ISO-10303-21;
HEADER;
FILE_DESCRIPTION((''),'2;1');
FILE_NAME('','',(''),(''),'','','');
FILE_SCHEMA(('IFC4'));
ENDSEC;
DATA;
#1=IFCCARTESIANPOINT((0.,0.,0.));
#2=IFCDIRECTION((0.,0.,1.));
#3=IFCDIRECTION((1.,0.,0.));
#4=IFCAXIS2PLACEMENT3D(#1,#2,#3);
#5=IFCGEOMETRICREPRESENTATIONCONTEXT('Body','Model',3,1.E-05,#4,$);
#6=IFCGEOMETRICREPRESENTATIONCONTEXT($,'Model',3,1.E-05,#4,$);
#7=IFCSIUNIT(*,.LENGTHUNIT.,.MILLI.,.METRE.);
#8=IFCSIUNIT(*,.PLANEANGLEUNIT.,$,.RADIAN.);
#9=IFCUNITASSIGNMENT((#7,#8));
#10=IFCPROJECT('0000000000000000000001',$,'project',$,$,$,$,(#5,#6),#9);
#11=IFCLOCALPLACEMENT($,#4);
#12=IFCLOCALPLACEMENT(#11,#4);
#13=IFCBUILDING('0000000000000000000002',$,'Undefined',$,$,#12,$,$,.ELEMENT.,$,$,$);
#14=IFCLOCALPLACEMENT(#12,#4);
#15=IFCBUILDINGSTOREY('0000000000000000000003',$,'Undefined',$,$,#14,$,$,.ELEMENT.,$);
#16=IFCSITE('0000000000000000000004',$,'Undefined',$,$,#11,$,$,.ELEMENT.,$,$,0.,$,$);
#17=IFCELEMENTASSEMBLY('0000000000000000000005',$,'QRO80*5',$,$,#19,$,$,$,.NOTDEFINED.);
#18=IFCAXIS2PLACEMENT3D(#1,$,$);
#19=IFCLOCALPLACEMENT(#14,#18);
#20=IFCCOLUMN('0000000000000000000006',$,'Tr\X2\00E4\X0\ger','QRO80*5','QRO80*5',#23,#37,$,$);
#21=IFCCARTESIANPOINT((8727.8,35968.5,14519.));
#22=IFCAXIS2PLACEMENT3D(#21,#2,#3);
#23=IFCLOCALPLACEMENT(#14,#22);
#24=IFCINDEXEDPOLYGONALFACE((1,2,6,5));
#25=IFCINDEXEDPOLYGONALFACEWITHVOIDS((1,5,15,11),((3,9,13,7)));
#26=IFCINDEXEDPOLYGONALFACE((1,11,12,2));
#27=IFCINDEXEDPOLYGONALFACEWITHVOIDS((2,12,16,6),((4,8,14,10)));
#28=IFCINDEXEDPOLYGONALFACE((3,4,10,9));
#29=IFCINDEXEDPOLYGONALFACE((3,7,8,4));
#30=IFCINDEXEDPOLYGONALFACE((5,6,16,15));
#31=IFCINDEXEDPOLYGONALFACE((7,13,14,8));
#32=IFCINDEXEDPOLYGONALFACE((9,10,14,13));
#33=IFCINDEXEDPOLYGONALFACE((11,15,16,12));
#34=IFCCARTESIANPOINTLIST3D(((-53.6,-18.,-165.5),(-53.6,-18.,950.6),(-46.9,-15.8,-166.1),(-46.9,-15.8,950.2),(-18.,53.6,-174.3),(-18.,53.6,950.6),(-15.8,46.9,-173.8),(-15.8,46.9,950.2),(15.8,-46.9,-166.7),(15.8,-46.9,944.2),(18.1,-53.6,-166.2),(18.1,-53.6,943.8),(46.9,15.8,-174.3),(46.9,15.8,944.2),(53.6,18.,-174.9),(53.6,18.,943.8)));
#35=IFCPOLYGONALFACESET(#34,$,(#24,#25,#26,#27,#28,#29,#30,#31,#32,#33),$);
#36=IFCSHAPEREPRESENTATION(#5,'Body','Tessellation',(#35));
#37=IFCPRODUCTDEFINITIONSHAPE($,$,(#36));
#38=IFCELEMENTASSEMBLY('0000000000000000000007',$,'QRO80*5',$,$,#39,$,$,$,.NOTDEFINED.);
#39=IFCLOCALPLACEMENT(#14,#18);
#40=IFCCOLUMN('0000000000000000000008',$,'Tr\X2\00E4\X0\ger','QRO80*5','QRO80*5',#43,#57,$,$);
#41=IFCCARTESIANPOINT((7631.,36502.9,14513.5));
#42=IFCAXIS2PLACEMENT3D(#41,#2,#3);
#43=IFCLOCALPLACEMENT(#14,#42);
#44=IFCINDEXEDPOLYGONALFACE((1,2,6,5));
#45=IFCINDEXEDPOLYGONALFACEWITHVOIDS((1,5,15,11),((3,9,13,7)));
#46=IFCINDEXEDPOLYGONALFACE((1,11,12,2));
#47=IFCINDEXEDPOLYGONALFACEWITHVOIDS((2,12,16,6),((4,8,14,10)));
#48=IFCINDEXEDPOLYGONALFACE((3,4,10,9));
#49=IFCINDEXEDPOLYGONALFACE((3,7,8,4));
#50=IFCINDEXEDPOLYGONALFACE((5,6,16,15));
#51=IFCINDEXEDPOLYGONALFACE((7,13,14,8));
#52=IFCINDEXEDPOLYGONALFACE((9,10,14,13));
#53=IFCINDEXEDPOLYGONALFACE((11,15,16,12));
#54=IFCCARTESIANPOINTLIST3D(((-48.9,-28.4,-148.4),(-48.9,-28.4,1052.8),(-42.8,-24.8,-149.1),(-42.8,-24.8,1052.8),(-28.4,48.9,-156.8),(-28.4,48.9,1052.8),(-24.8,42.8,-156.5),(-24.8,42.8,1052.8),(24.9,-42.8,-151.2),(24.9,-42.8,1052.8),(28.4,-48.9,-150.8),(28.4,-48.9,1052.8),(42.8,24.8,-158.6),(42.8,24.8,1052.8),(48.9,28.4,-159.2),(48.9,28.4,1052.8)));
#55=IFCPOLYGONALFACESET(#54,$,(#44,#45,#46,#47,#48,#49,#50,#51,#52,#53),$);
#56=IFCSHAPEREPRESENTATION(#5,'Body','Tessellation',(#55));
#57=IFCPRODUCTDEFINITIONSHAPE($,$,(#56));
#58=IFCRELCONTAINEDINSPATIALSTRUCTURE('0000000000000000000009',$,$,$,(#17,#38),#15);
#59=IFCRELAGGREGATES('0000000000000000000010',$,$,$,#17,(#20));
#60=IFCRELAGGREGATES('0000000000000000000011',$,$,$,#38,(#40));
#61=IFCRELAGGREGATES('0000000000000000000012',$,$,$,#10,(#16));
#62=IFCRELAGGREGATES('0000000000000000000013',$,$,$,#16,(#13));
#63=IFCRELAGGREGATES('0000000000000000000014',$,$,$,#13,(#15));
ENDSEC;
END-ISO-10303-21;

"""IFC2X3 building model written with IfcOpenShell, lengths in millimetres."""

from ifc_helpers import new_model, si_unit, frame, origin_with_axes, origin_2d_with_axis, place, context, project, spatial, hollow_rectangle, extrude, clip, halfspace, element, aggregate, save


model = new_model("IFC2X3")

# Units and contexts
model_context_1 = context("Model", 3, precision=1e-05, world=origin_with_axes(), identifier="Body")
model_context_2 = context("Model", 3, precision=1e-05, world=origin_with_axes())
ifc_project = project(units=[si_unit("LENGTHUNIT", "METRE", prefix="MILLI"), si_unit("PLANEANGLEUNIT", "RADIAN")], contexts=[model_context_1, model_context_2])

# Site, building, storey
site_placement = place(None, origin_with_axes())
site = spatial("IfcSite", under=ifc_project, at=site_placement, Name="Undefined", CompositionType="ELEMENT", RefElevation=0.0)
building_placement = place(site_placement, origin_with_axes())
building = spatial("IfcBuilding", under=site, at=building_placement, Name="Undefined", CompositionType="ELEMENT")
storey_placement = place(building_placement, origin_with_axes())
storey = spatial("IfcBuildingStorey", under=building, at=storey_placement, Name="Undefined", CompositionType="ELEMENT")

# Element assemblies, columns
assembly_1 = element("IfcElementAssembly", 1, inside=storey, Name="QRO80*5", PredefinedType="NOTDEFINED")
column_1_placement = place(storey_placement, frame((8727.8, 35968.5, 14519.0), z_axis=(0.0, 0.0, 1.0), x_axis=(1.0, 0.0, 0.0)))
column_1 = element("IfcColumn", 2, at=column_1_placement, Name="Träger", Description="QRO80*5", ObjectType="QRO80*5", context=model_context_1, shape_type="Clipping", body=[
    clip(clip(extrude(hollow_rectangle(XDim=80.0, YDim=80.0, WallThickness=5.0, at=origin_2d_with_axis()), frame((0.0, 0.0, 955.4), z_axis=(0.0, 0.0, -1.0), x_axis=(-0.895769, 0.444521, 0.000002)), (0.0, 0.0, 1.0), 1133.8), halfspace(frame((17.8, 35.8, 947.2), z_axis=(-0.076083, 0.037747, -0.996387), x_axis=(-0.892532, 0.442915, 0.084932)), True)), halfspace(frame((35.8, -17.8, -170.6), z_axis=(0.055557, 0.09362, 0.994057), x_axis=(-0.440717, -0.891059, 0.108551)), True)),
])
aggregate(assembly_1, [column_1])
assembly_2 = element("IfcElementAssembly", 3, inside=storey, Name="QRO80*5", PredefinedType="NOTDEFINED")
column_2_placement = place(storey_placement, frame((7631.0, 36502.9, 14513.5), z_axis=(0.0, 0.0, 1.0), x_axis=(1.0, 0.0, 0.0)))
column_2 = element("IfcColumn", 4, at=column_2_placement, Name="Träger", Description="QRO80*5", ObjectType="QRO80*5", context=model_context_1, shape_type="Clipping", body=[
    clip(clip(extrude(hollow_rectangle(XDim=80.0, YDim=80.0, WallThickness=5.0, at=origin_2d_with_axis()), frame((0.0, 0.0, 1052.8), z_axis=(0.0, 0.0, -1.0), x_axis=(-0.256576, -0.966524, 0.000001)), (0.0, 0.0, 1.0), 1212.1), halfspace(frame((-35.1, 17.4, -153.5), z_axis=(0.055557, 0.09362, 0.994057), x_axis=(0.440717, 0.891059, -0.108551)), True)), halfspace(frame((-38.6, 10.4, 1052.8), z_axis=(0.0, 0.0, -1.0), x_axis=(-0.258822, -0.965925, -0.000005)), True)),
])
aggregate(assembly_2, [column_2])

save(model, "model.ifc")
